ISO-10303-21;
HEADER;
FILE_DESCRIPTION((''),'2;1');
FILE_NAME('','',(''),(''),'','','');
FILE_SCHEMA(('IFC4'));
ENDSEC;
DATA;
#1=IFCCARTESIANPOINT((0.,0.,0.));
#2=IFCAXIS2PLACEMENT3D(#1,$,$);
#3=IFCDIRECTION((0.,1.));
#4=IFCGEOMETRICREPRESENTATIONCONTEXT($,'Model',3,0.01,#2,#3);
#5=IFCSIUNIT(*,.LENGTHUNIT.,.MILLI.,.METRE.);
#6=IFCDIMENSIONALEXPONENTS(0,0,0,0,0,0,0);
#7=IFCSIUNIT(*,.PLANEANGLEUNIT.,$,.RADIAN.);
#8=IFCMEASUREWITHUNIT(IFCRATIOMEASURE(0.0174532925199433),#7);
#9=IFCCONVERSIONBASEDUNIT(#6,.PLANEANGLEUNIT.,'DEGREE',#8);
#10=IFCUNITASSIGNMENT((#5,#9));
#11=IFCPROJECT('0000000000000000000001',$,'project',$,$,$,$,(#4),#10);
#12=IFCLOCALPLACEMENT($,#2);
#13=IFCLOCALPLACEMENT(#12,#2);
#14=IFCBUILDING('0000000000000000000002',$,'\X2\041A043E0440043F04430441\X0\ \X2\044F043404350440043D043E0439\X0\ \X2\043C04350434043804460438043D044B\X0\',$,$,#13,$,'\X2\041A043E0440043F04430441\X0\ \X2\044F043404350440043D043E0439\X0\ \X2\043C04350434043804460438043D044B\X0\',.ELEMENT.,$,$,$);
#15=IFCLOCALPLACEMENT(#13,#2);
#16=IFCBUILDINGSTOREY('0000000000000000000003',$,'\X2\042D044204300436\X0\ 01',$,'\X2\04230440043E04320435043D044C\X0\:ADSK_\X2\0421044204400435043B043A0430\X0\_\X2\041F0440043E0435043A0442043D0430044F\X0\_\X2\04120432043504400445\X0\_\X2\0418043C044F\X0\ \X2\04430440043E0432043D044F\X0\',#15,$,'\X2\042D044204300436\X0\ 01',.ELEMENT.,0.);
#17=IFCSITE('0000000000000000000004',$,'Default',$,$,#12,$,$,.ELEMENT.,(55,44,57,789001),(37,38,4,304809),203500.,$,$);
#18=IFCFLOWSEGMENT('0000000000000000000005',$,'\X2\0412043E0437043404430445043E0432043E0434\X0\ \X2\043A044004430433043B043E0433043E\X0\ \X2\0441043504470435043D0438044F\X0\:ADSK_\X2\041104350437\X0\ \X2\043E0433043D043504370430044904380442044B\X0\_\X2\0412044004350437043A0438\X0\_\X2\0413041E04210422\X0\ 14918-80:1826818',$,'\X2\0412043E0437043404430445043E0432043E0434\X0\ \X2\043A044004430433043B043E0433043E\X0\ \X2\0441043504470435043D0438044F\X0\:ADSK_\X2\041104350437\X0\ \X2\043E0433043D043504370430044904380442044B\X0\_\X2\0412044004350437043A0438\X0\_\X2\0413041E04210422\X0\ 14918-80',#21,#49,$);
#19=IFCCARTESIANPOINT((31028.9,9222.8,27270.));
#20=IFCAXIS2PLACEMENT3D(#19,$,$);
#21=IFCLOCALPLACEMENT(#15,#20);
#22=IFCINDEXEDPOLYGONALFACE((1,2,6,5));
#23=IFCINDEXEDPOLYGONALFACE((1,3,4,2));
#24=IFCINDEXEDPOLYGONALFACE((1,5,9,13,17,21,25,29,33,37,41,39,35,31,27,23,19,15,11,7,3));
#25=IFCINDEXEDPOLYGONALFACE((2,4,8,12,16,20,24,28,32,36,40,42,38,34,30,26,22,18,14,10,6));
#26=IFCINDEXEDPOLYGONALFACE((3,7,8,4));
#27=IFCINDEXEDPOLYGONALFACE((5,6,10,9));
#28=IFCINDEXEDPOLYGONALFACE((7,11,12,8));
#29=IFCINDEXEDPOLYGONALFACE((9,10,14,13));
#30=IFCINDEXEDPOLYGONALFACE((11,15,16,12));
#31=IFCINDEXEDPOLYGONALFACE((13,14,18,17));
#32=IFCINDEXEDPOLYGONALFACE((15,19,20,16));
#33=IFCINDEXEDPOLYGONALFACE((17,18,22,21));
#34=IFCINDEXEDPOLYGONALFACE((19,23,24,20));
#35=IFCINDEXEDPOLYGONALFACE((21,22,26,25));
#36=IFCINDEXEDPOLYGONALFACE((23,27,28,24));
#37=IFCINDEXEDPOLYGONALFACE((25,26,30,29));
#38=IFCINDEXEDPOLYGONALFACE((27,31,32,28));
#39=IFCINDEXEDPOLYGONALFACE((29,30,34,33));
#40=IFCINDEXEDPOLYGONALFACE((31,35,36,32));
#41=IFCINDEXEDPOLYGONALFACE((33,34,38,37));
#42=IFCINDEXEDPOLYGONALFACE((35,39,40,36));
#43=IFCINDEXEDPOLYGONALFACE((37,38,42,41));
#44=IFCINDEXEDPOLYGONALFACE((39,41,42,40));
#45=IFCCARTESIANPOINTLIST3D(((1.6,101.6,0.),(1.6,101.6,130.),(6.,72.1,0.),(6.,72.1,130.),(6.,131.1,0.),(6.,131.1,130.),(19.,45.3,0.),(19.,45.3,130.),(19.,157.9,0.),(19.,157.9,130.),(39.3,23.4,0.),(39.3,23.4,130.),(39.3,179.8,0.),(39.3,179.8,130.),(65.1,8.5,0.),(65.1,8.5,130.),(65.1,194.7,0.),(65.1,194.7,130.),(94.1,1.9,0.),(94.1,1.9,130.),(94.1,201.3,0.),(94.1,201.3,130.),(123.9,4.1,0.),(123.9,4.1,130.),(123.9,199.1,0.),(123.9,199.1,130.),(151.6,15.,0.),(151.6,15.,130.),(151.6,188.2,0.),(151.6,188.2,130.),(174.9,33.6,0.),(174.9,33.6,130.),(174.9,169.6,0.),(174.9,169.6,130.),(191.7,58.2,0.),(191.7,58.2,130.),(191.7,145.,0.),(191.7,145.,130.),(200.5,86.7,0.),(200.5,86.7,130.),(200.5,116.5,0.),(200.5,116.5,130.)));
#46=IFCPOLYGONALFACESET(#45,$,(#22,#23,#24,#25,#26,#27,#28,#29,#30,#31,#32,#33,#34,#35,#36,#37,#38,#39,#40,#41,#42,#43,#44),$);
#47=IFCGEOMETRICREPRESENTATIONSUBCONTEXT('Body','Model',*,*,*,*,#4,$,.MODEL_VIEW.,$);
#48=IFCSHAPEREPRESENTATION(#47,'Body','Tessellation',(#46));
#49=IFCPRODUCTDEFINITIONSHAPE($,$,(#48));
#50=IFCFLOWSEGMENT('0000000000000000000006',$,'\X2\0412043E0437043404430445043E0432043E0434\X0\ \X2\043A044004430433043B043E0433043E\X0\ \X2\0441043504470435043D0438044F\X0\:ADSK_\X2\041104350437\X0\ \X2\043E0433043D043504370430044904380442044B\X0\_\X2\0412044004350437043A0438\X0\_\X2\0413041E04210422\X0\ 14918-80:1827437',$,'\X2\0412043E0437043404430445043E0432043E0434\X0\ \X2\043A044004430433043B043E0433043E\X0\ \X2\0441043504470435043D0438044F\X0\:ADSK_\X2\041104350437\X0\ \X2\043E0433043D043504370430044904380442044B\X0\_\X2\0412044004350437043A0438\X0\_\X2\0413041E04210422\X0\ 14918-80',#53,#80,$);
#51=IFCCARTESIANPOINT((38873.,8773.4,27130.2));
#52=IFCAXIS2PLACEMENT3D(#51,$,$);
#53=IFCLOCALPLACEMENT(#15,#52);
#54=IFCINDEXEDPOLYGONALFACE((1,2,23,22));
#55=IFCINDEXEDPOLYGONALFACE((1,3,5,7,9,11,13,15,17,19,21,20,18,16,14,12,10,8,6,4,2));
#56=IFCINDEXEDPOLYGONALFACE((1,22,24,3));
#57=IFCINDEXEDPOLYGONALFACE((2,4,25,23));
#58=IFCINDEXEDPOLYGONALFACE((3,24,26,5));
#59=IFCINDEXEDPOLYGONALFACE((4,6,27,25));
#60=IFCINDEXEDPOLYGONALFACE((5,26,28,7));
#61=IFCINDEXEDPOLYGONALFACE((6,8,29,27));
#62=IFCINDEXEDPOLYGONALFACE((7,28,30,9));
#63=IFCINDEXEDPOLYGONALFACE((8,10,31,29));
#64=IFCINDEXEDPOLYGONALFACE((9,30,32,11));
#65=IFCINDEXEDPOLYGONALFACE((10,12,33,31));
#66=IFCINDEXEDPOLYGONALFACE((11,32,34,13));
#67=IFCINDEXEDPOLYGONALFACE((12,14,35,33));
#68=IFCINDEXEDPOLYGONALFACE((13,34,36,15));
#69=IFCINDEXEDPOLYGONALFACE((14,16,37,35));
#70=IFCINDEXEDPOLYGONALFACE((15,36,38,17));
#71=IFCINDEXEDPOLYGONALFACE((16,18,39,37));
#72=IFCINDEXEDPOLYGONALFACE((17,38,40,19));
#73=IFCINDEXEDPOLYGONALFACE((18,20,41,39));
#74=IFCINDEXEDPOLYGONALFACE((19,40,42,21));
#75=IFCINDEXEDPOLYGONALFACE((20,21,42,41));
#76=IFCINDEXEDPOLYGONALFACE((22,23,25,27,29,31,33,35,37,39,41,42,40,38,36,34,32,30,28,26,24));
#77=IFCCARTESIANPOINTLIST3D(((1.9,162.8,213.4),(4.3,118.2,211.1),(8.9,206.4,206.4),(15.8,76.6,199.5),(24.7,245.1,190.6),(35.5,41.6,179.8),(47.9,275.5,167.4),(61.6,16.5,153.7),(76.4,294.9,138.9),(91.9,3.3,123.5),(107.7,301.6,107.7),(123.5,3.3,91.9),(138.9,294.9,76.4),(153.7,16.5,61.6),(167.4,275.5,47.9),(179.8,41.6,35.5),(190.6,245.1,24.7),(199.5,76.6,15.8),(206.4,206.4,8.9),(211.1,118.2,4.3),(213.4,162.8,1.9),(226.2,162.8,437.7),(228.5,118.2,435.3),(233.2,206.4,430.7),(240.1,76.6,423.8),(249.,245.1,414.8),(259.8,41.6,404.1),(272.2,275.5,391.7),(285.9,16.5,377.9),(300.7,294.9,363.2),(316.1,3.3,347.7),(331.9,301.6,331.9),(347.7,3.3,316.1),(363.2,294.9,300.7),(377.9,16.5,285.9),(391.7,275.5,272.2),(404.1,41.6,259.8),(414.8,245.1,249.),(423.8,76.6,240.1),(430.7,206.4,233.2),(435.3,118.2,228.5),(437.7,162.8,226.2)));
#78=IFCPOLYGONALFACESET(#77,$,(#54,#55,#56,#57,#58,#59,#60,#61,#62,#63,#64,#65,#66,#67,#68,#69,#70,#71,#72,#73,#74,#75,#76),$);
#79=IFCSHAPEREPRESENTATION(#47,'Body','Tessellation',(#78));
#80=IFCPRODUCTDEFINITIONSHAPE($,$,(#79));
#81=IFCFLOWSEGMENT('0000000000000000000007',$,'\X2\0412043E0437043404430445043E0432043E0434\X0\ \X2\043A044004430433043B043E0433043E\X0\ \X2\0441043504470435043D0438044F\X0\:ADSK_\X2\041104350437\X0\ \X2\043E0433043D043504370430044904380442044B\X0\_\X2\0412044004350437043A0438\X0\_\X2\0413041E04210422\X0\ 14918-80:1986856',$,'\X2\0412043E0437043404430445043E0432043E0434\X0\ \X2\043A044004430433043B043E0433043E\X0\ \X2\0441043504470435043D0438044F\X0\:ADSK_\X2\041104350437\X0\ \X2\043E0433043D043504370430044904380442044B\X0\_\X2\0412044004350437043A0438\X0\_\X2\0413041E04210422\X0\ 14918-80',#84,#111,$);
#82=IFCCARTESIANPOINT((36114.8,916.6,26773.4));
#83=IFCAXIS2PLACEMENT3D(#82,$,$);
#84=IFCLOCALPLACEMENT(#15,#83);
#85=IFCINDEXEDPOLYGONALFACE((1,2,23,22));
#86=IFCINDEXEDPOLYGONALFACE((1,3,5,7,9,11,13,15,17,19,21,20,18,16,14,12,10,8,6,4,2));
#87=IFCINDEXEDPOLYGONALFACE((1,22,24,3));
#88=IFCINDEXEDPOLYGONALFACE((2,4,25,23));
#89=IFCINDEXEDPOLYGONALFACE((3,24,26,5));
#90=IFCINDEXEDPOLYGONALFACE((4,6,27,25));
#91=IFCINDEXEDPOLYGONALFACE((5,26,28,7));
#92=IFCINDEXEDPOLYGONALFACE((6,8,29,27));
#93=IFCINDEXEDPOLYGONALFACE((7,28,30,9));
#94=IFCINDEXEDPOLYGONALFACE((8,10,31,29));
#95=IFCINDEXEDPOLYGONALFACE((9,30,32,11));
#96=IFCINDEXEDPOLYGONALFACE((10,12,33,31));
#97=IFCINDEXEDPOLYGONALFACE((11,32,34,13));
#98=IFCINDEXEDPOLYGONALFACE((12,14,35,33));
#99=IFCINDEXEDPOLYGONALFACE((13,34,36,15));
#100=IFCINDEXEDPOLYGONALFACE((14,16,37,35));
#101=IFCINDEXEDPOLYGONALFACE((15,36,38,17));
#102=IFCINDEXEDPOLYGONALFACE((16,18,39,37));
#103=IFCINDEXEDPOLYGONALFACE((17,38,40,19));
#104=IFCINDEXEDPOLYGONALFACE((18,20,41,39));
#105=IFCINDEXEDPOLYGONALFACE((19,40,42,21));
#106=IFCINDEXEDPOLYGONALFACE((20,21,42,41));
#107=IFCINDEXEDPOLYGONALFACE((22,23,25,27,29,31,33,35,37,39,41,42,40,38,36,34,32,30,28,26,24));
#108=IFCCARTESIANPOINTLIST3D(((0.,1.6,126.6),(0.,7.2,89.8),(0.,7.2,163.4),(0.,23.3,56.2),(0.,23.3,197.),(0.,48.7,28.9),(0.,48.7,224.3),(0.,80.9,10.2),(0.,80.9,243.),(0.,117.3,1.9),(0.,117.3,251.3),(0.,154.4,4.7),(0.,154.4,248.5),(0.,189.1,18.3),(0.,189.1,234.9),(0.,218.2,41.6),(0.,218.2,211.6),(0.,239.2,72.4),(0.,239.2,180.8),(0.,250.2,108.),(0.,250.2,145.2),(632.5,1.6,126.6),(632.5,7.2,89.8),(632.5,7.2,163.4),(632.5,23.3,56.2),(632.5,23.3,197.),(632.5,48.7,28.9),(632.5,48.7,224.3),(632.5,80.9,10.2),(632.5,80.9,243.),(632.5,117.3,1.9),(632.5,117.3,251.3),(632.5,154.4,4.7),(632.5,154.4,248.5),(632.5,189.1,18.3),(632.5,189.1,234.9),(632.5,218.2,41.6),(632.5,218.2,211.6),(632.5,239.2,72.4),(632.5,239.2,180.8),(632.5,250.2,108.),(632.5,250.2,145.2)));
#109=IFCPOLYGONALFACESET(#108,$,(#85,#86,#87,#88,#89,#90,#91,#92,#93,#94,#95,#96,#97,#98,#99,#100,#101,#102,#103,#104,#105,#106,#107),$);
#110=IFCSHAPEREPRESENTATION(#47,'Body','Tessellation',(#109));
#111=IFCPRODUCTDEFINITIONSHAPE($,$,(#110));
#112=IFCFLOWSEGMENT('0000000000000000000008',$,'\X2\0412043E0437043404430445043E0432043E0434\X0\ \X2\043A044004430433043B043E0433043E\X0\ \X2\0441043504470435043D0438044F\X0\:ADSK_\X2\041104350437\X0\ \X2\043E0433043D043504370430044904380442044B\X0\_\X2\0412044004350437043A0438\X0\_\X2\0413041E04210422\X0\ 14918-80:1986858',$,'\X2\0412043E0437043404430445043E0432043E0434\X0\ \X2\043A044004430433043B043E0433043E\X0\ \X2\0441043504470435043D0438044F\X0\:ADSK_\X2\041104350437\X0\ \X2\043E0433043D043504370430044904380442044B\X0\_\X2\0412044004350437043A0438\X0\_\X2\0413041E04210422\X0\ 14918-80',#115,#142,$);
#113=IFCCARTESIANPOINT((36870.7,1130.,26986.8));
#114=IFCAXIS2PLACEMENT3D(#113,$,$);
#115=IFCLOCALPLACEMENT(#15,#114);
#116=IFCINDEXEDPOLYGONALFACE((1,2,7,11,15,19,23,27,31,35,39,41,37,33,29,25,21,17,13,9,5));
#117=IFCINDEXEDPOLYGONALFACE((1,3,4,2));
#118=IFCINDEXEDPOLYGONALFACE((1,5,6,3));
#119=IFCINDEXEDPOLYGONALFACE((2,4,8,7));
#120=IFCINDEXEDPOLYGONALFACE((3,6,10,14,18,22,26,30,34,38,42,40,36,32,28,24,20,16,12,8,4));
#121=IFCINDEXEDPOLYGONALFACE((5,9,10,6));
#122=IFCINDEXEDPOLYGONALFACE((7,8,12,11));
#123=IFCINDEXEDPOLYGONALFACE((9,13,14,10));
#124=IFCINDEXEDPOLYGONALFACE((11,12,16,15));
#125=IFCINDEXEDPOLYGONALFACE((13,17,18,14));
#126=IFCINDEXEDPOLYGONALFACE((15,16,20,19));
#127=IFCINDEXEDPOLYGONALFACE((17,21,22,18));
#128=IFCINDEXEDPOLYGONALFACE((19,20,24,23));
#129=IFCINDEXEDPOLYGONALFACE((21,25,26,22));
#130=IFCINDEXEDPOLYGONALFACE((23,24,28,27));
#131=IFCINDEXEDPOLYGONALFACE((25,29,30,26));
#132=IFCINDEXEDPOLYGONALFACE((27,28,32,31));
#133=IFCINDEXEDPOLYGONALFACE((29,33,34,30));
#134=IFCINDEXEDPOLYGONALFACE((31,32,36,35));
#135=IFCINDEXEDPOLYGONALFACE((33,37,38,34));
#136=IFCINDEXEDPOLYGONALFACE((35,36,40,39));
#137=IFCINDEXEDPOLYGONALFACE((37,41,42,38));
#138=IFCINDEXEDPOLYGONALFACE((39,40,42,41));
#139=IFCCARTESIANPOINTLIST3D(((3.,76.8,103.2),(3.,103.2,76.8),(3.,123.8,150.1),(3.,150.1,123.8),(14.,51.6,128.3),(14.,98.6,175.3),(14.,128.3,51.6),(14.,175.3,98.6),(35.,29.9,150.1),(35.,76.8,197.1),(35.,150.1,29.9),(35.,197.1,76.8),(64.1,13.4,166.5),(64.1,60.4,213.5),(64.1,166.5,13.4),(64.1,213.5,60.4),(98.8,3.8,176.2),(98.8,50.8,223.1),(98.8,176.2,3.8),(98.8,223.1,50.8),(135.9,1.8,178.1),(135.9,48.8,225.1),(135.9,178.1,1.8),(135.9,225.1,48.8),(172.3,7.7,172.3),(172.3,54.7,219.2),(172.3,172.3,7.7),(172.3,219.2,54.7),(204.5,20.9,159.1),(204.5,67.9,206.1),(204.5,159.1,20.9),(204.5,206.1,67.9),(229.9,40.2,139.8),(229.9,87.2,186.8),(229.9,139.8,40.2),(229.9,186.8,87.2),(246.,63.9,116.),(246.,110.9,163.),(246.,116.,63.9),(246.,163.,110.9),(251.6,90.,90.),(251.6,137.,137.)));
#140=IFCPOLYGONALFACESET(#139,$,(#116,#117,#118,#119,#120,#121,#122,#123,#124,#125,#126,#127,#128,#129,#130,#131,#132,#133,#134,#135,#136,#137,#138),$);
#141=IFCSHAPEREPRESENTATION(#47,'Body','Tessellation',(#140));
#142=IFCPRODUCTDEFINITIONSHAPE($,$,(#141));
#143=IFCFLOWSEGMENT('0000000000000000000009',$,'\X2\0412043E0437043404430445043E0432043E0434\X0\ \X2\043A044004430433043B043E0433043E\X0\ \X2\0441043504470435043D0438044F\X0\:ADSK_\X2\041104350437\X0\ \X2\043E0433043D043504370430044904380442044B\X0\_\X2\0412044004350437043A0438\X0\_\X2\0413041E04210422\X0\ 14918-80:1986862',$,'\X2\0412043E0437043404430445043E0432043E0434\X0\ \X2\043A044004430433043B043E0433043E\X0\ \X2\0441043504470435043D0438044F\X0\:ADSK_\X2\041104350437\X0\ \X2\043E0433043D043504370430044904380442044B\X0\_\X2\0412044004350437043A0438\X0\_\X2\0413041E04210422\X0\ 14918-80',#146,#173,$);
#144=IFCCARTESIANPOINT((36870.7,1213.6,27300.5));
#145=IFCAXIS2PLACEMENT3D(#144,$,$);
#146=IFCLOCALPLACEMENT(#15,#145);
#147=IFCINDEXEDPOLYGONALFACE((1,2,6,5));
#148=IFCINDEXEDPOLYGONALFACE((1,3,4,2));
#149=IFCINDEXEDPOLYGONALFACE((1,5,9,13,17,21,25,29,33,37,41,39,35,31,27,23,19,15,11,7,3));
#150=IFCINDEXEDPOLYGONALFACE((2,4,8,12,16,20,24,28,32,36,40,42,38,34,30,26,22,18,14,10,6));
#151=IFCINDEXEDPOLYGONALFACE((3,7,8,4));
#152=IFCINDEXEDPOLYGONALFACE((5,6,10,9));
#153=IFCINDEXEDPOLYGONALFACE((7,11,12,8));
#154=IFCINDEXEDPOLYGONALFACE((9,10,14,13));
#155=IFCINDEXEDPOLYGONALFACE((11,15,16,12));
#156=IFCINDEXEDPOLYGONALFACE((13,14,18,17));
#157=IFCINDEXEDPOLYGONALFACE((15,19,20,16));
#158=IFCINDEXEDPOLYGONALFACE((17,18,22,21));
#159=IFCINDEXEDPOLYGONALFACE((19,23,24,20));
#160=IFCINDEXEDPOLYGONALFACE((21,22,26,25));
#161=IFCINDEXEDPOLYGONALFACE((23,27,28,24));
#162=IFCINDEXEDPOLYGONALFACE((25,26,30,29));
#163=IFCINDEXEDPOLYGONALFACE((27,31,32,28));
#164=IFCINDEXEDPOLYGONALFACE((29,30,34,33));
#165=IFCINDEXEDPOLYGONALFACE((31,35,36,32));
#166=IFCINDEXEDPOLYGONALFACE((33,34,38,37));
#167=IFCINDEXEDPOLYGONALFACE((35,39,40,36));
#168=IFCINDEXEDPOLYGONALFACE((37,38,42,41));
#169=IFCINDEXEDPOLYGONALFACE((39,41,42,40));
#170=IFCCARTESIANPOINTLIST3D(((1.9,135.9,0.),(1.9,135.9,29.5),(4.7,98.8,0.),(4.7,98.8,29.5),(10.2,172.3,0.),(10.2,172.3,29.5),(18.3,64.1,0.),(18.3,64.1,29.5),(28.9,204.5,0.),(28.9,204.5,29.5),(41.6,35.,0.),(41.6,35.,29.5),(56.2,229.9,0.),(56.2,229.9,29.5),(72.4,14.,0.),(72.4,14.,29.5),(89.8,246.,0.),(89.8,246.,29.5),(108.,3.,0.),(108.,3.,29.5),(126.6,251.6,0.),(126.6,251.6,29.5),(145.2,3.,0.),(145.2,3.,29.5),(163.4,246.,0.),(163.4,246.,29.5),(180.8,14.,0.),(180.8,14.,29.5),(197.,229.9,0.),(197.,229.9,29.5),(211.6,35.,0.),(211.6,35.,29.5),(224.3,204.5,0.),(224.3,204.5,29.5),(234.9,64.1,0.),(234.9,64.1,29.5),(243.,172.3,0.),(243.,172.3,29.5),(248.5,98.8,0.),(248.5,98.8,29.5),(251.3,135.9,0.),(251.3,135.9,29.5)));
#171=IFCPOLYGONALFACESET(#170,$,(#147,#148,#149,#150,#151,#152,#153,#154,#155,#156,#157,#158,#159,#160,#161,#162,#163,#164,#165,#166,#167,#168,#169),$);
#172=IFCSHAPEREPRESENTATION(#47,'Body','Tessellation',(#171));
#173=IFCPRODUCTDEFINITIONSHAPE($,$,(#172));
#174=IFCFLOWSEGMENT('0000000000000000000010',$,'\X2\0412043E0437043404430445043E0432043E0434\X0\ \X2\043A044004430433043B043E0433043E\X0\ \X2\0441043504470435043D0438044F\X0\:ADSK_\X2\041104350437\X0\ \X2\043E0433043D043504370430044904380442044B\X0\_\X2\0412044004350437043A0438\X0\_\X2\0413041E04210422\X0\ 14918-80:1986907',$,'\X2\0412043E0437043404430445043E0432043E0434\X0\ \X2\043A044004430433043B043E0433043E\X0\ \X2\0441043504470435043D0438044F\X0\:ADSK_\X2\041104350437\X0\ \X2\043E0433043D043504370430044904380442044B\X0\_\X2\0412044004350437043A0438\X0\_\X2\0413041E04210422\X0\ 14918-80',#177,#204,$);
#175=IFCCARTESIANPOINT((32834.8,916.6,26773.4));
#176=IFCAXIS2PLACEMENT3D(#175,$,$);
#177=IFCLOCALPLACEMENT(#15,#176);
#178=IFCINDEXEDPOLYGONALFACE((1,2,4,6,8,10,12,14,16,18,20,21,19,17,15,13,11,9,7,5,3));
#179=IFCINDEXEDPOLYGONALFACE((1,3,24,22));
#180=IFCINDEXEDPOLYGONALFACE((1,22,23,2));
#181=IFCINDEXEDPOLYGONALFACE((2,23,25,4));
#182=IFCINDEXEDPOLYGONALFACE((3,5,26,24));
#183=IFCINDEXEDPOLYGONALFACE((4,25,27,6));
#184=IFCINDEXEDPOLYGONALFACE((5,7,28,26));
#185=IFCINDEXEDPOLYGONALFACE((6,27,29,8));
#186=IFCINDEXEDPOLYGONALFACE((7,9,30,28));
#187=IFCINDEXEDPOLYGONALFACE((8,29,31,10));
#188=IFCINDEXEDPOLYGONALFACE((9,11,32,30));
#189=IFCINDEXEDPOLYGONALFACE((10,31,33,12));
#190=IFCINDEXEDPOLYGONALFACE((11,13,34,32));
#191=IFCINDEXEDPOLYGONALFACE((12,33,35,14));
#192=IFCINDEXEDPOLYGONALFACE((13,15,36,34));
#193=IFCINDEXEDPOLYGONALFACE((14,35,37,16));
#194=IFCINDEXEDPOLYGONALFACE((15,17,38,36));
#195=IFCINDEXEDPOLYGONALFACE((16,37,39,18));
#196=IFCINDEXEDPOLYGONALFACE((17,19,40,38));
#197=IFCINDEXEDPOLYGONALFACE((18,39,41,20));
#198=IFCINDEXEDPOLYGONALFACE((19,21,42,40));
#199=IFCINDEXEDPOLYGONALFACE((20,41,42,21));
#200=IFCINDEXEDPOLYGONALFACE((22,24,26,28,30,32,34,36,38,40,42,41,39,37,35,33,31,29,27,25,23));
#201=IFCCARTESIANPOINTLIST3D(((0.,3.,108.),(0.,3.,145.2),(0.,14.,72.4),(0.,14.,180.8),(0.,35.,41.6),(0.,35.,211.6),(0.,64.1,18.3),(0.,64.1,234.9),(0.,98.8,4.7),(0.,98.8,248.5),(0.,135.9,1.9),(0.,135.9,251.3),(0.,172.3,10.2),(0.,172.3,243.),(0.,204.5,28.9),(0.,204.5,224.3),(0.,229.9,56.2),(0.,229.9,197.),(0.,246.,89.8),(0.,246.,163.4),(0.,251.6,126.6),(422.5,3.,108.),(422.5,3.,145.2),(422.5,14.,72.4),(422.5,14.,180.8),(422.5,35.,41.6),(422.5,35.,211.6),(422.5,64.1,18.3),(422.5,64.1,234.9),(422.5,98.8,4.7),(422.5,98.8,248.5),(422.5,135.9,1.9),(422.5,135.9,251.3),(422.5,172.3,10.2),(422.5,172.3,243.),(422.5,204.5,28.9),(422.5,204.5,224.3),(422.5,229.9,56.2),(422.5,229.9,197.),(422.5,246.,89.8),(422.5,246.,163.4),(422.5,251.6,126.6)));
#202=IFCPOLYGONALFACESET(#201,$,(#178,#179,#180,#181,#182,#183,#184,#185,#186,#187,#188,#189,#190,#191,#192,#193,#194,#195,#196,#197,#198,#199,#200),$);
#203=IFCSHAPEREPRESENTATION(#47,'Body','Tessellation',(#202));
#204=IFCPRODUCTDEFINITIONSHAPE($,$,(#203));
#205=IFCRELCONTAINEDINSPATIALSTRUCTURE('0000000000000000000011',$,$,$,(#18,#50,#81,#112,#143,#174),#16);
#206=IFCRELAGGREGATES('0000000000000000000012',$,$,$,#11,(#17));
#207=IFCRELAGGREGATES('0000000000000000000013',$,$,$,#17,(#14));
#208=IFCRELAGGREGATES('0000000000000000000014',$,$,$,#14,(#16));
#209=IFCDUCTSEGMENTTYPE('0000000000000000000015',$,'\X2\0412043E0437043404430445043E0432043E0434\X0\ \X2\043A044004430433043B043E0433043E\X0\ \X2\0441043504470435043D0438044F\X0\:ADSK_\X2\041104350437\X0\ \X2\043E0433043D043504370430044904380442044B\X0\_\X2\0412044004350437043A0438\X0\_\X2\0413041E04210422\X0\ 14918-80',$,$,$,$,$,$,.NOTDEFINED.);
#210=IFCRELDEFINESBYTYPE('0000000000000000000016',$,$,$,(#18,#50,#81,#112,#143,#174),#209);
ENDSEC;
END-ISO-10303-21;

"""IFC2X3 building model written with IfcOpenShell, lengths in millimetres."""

from ifc_helpers import new_model, entity, si_unit, converted_unit, direction, frame, origin, origin_2d_with_axis, place, context, subcontext, project, spatial, circle, extrude, type_object, element, save


model = new_model("IFC2X3")

# Units and contexts
model_context = context("Model", 3, precision=0.01, world=origin(), true_north=direction((0.0, 1.0)))
body_context = subcontext(model_context, "Body", "Model", "MODEL_VIEW")
ifc_project = project(units=[si_unit("LENGTHUNIT", "METRE", prefix="MILLI"), converted_unit("PLANEANGLEUNIT", "DEGREE", entity("IfcRatioMeasure", 0.0174532925199433), si_unit("PLANEANGLEUNIT", "RADIAN"), dimensions=[0, 0, 0, 0, 0, 0, 0])], contexts=[model_context])

# Site, building, storey
site_placement = place(None, origin())
site = spatial("IfcSite", under=ifc_project, at=site_placement, Name="Default", CompositionType="ELEMENT", RefLatitude=(55, 44, 57, 789001), RefLongitude=(37, 38, 4, 304809), RefElevation=203500.0)
building_placement = place(site_placement, origin())
building = spatial("IfcBuilding", under=site, at=building_placement, Name="Корпус ядерной медицины", LongName="Корпус ядерной медицины", CompositionType="ELEMENT")
storey_placement = place(building_placement, origin())
storey = spatial("IfcBuildingStorey", under=building, at=storey_placement, Name="Этаж 01", ObjectType="Уровень:ADSK_Стрелка_Проектная_Вверх_Имя уровня", LongName="Этаж 01", CompositionType="ELEMENT", Elevation=0.0)

# Flow segments
duct_segment_type_1 = type_object("IfcDuctSegmentType", Name="Воздуховод круглого сечения:ADSK_Без огнезащиты_Врезки_ГОСТ 14918-80", PredefinedType="NOTDEFINED")
flow_segment_1_placement = place(storey_placement, frame((31028.9, 9222.8, 27270.0)))
element("IfcFlowSegment", 1, at=flow_segment_1_placement, inside=storey, type_object=duct_segment_type_1, Name="Воздуховод круглого сечения:ADSK_Без огнезащиты_Врезки_ГОСТ 14918-80:1826818", ObjectType="Воздуховод круглого сечения:ADSK_Без огнезащиты_Врезки_ГОСТ 14918-80", context=body_context, shape_type="SweptSolid", body=[
    extrude(circle(Radius=100.0, at=origin_2d_with_axis()), frame((101.6, 101.6, 0.0), z_axis=(0.0, 0.0, 1.0), x_axis=(-1.0, 0.0, 0.0)), (0.0, 0.0, 1.0), 130.0),
])
flow_segment_2_placement = place(storey_placement, frame((38873.0, 8773.4, 27130.2)))
element("IfcFlowSegment", 2, at=flow_segment_2_placement, inside=storey, type_object=duct_segment_type_1, Name="Воздуховод круглого сечения:ADSK_Без огнезащиты_Врезки_ГОСТ 14918-80:1827437", ObjectType="Воздуховод круглого сечения:ADSK_Без огнезащиты_Врезки_ГОСТ 14918-80", context=body_context, shape_type="SweptSolid", body=[
    extrude(circle(Radius=150.0, at=origin_2d_with_axis()), frame((107.7, 151.6, 107.7), z_axis=(0.707107, 0.0, 0.707107), x_axis=(0.0, 1.0, 0.0)), (0.0, 0.0, 1.0), 317.2),
])
flow_segment_3_placement = place(storey_placement, frame((36114.8, 916.6, 26773.4)))
element("IfcFlowSegment", 3, at=flow_segment_3_placement, inside=storey, type_object=duct_segment_type_1, Name="Воздуховод круглого сечения:ADSK_Без огнезащиты_Врезки_ГОСТ 14918-80:1986856", ObjectType="Воздуховод круглого сечения:ADSK_Без огнезащиты_Врезки_ГОСТ 14918-80", context=body_context, shape_type="SweptSolid", body=[
    extrude(circle(Radius=125.0, at=origin_2d_with_axis()), frame((0.0, 126.6, 126.6), z_axis=(1.0, 0.0, 0.0), x_axis=(0.0, -1.0, 0.0)), (0.0, 0.0, 1.0), 632.5),
])
flow_segment_4_placement = place(storey_placement, frame((36870.7, 1130.0, 26986.8)))
element("IfcFlowSegment", 4, at=flow_segment_4_placement, inside=storey, type_object=duct_segment_type_1, Name="Воздуховод круглого сечения:ADSK_Без огнезащиты_Врезки_ГОСТ 14918-80:1986858", ObjectType="Воздуховод круглого сечения:ADSK_Без огнезащиты_Врезки_ГОСТ 14918-80", context=body_context, shape_type="SweptSolid", body=[
    extrude(circle(Radius=125.0, at=origin_2d_with_axis()), frame((126.6, 90.0, 90.0), z_axis=(0.0, 0.707107, 0.707107), x_axis=(1.0, 0.0, 0.0)), (0.0, 0.0, 1.0), 66.4),
])
flow_segment_5_placement = place(storey_placement, frame((36870.7, 1213.6, 27300.5)))
element("IfcFlowSegment", 5, at=flow_segment_5_placement, inside=storey, type_object=duct_segment_type_1, Name="Воздуховод круглого сечения:ADSK_Без огнезащиты_Врезки_ГОСТ 14918-80:1986862", ObjectType="Воздуховод круглого сечения:ADSK_Без огнезащиты_Врезки_ГОСТ 14918-80", context=body_context, shape_type="SweptSolid", body=[
    extrude(circle(Radius=125.0, at=origin_2d_with_axis()), frame((126.6, 126.6, 0.0), z_axis=(0.0, 0.0, 1.0), x_axis=(0.0, 1.0, 0.0)), (0.0, 0.0, 1.0), 29.5),
])
flow_segment_6_placement = place(storey_placement, frame((32834.8, 916.6, 26773.4)))
element("IfcFlowSegment", 6, at=flow_segment_6_placement, inside=storey, type_object=duct_segment_type_1, Name="Воздуховод круглого сечения:ADSK_Без огнезащиты_Врезки_ГОСТ 14918-80:1986907", ObjectType="Воздуховод круглого сечения:ADSK_Без огнезащиты_Врезки_ГОСТ 14918-80", context=body_context, shape_type="SweptSolid", body=[
    extrude(circle(Radius=125.0, at=origin_2d_with_axis()), frame((0.0, 126.6, 126.6), z_axis=(1.0, 0.0, 0.0), x_axis=(0.0, 1.0, 0.0)), (0.0, 0.0, 1.0), 422.5),
])

save(model, "model.ifc")
